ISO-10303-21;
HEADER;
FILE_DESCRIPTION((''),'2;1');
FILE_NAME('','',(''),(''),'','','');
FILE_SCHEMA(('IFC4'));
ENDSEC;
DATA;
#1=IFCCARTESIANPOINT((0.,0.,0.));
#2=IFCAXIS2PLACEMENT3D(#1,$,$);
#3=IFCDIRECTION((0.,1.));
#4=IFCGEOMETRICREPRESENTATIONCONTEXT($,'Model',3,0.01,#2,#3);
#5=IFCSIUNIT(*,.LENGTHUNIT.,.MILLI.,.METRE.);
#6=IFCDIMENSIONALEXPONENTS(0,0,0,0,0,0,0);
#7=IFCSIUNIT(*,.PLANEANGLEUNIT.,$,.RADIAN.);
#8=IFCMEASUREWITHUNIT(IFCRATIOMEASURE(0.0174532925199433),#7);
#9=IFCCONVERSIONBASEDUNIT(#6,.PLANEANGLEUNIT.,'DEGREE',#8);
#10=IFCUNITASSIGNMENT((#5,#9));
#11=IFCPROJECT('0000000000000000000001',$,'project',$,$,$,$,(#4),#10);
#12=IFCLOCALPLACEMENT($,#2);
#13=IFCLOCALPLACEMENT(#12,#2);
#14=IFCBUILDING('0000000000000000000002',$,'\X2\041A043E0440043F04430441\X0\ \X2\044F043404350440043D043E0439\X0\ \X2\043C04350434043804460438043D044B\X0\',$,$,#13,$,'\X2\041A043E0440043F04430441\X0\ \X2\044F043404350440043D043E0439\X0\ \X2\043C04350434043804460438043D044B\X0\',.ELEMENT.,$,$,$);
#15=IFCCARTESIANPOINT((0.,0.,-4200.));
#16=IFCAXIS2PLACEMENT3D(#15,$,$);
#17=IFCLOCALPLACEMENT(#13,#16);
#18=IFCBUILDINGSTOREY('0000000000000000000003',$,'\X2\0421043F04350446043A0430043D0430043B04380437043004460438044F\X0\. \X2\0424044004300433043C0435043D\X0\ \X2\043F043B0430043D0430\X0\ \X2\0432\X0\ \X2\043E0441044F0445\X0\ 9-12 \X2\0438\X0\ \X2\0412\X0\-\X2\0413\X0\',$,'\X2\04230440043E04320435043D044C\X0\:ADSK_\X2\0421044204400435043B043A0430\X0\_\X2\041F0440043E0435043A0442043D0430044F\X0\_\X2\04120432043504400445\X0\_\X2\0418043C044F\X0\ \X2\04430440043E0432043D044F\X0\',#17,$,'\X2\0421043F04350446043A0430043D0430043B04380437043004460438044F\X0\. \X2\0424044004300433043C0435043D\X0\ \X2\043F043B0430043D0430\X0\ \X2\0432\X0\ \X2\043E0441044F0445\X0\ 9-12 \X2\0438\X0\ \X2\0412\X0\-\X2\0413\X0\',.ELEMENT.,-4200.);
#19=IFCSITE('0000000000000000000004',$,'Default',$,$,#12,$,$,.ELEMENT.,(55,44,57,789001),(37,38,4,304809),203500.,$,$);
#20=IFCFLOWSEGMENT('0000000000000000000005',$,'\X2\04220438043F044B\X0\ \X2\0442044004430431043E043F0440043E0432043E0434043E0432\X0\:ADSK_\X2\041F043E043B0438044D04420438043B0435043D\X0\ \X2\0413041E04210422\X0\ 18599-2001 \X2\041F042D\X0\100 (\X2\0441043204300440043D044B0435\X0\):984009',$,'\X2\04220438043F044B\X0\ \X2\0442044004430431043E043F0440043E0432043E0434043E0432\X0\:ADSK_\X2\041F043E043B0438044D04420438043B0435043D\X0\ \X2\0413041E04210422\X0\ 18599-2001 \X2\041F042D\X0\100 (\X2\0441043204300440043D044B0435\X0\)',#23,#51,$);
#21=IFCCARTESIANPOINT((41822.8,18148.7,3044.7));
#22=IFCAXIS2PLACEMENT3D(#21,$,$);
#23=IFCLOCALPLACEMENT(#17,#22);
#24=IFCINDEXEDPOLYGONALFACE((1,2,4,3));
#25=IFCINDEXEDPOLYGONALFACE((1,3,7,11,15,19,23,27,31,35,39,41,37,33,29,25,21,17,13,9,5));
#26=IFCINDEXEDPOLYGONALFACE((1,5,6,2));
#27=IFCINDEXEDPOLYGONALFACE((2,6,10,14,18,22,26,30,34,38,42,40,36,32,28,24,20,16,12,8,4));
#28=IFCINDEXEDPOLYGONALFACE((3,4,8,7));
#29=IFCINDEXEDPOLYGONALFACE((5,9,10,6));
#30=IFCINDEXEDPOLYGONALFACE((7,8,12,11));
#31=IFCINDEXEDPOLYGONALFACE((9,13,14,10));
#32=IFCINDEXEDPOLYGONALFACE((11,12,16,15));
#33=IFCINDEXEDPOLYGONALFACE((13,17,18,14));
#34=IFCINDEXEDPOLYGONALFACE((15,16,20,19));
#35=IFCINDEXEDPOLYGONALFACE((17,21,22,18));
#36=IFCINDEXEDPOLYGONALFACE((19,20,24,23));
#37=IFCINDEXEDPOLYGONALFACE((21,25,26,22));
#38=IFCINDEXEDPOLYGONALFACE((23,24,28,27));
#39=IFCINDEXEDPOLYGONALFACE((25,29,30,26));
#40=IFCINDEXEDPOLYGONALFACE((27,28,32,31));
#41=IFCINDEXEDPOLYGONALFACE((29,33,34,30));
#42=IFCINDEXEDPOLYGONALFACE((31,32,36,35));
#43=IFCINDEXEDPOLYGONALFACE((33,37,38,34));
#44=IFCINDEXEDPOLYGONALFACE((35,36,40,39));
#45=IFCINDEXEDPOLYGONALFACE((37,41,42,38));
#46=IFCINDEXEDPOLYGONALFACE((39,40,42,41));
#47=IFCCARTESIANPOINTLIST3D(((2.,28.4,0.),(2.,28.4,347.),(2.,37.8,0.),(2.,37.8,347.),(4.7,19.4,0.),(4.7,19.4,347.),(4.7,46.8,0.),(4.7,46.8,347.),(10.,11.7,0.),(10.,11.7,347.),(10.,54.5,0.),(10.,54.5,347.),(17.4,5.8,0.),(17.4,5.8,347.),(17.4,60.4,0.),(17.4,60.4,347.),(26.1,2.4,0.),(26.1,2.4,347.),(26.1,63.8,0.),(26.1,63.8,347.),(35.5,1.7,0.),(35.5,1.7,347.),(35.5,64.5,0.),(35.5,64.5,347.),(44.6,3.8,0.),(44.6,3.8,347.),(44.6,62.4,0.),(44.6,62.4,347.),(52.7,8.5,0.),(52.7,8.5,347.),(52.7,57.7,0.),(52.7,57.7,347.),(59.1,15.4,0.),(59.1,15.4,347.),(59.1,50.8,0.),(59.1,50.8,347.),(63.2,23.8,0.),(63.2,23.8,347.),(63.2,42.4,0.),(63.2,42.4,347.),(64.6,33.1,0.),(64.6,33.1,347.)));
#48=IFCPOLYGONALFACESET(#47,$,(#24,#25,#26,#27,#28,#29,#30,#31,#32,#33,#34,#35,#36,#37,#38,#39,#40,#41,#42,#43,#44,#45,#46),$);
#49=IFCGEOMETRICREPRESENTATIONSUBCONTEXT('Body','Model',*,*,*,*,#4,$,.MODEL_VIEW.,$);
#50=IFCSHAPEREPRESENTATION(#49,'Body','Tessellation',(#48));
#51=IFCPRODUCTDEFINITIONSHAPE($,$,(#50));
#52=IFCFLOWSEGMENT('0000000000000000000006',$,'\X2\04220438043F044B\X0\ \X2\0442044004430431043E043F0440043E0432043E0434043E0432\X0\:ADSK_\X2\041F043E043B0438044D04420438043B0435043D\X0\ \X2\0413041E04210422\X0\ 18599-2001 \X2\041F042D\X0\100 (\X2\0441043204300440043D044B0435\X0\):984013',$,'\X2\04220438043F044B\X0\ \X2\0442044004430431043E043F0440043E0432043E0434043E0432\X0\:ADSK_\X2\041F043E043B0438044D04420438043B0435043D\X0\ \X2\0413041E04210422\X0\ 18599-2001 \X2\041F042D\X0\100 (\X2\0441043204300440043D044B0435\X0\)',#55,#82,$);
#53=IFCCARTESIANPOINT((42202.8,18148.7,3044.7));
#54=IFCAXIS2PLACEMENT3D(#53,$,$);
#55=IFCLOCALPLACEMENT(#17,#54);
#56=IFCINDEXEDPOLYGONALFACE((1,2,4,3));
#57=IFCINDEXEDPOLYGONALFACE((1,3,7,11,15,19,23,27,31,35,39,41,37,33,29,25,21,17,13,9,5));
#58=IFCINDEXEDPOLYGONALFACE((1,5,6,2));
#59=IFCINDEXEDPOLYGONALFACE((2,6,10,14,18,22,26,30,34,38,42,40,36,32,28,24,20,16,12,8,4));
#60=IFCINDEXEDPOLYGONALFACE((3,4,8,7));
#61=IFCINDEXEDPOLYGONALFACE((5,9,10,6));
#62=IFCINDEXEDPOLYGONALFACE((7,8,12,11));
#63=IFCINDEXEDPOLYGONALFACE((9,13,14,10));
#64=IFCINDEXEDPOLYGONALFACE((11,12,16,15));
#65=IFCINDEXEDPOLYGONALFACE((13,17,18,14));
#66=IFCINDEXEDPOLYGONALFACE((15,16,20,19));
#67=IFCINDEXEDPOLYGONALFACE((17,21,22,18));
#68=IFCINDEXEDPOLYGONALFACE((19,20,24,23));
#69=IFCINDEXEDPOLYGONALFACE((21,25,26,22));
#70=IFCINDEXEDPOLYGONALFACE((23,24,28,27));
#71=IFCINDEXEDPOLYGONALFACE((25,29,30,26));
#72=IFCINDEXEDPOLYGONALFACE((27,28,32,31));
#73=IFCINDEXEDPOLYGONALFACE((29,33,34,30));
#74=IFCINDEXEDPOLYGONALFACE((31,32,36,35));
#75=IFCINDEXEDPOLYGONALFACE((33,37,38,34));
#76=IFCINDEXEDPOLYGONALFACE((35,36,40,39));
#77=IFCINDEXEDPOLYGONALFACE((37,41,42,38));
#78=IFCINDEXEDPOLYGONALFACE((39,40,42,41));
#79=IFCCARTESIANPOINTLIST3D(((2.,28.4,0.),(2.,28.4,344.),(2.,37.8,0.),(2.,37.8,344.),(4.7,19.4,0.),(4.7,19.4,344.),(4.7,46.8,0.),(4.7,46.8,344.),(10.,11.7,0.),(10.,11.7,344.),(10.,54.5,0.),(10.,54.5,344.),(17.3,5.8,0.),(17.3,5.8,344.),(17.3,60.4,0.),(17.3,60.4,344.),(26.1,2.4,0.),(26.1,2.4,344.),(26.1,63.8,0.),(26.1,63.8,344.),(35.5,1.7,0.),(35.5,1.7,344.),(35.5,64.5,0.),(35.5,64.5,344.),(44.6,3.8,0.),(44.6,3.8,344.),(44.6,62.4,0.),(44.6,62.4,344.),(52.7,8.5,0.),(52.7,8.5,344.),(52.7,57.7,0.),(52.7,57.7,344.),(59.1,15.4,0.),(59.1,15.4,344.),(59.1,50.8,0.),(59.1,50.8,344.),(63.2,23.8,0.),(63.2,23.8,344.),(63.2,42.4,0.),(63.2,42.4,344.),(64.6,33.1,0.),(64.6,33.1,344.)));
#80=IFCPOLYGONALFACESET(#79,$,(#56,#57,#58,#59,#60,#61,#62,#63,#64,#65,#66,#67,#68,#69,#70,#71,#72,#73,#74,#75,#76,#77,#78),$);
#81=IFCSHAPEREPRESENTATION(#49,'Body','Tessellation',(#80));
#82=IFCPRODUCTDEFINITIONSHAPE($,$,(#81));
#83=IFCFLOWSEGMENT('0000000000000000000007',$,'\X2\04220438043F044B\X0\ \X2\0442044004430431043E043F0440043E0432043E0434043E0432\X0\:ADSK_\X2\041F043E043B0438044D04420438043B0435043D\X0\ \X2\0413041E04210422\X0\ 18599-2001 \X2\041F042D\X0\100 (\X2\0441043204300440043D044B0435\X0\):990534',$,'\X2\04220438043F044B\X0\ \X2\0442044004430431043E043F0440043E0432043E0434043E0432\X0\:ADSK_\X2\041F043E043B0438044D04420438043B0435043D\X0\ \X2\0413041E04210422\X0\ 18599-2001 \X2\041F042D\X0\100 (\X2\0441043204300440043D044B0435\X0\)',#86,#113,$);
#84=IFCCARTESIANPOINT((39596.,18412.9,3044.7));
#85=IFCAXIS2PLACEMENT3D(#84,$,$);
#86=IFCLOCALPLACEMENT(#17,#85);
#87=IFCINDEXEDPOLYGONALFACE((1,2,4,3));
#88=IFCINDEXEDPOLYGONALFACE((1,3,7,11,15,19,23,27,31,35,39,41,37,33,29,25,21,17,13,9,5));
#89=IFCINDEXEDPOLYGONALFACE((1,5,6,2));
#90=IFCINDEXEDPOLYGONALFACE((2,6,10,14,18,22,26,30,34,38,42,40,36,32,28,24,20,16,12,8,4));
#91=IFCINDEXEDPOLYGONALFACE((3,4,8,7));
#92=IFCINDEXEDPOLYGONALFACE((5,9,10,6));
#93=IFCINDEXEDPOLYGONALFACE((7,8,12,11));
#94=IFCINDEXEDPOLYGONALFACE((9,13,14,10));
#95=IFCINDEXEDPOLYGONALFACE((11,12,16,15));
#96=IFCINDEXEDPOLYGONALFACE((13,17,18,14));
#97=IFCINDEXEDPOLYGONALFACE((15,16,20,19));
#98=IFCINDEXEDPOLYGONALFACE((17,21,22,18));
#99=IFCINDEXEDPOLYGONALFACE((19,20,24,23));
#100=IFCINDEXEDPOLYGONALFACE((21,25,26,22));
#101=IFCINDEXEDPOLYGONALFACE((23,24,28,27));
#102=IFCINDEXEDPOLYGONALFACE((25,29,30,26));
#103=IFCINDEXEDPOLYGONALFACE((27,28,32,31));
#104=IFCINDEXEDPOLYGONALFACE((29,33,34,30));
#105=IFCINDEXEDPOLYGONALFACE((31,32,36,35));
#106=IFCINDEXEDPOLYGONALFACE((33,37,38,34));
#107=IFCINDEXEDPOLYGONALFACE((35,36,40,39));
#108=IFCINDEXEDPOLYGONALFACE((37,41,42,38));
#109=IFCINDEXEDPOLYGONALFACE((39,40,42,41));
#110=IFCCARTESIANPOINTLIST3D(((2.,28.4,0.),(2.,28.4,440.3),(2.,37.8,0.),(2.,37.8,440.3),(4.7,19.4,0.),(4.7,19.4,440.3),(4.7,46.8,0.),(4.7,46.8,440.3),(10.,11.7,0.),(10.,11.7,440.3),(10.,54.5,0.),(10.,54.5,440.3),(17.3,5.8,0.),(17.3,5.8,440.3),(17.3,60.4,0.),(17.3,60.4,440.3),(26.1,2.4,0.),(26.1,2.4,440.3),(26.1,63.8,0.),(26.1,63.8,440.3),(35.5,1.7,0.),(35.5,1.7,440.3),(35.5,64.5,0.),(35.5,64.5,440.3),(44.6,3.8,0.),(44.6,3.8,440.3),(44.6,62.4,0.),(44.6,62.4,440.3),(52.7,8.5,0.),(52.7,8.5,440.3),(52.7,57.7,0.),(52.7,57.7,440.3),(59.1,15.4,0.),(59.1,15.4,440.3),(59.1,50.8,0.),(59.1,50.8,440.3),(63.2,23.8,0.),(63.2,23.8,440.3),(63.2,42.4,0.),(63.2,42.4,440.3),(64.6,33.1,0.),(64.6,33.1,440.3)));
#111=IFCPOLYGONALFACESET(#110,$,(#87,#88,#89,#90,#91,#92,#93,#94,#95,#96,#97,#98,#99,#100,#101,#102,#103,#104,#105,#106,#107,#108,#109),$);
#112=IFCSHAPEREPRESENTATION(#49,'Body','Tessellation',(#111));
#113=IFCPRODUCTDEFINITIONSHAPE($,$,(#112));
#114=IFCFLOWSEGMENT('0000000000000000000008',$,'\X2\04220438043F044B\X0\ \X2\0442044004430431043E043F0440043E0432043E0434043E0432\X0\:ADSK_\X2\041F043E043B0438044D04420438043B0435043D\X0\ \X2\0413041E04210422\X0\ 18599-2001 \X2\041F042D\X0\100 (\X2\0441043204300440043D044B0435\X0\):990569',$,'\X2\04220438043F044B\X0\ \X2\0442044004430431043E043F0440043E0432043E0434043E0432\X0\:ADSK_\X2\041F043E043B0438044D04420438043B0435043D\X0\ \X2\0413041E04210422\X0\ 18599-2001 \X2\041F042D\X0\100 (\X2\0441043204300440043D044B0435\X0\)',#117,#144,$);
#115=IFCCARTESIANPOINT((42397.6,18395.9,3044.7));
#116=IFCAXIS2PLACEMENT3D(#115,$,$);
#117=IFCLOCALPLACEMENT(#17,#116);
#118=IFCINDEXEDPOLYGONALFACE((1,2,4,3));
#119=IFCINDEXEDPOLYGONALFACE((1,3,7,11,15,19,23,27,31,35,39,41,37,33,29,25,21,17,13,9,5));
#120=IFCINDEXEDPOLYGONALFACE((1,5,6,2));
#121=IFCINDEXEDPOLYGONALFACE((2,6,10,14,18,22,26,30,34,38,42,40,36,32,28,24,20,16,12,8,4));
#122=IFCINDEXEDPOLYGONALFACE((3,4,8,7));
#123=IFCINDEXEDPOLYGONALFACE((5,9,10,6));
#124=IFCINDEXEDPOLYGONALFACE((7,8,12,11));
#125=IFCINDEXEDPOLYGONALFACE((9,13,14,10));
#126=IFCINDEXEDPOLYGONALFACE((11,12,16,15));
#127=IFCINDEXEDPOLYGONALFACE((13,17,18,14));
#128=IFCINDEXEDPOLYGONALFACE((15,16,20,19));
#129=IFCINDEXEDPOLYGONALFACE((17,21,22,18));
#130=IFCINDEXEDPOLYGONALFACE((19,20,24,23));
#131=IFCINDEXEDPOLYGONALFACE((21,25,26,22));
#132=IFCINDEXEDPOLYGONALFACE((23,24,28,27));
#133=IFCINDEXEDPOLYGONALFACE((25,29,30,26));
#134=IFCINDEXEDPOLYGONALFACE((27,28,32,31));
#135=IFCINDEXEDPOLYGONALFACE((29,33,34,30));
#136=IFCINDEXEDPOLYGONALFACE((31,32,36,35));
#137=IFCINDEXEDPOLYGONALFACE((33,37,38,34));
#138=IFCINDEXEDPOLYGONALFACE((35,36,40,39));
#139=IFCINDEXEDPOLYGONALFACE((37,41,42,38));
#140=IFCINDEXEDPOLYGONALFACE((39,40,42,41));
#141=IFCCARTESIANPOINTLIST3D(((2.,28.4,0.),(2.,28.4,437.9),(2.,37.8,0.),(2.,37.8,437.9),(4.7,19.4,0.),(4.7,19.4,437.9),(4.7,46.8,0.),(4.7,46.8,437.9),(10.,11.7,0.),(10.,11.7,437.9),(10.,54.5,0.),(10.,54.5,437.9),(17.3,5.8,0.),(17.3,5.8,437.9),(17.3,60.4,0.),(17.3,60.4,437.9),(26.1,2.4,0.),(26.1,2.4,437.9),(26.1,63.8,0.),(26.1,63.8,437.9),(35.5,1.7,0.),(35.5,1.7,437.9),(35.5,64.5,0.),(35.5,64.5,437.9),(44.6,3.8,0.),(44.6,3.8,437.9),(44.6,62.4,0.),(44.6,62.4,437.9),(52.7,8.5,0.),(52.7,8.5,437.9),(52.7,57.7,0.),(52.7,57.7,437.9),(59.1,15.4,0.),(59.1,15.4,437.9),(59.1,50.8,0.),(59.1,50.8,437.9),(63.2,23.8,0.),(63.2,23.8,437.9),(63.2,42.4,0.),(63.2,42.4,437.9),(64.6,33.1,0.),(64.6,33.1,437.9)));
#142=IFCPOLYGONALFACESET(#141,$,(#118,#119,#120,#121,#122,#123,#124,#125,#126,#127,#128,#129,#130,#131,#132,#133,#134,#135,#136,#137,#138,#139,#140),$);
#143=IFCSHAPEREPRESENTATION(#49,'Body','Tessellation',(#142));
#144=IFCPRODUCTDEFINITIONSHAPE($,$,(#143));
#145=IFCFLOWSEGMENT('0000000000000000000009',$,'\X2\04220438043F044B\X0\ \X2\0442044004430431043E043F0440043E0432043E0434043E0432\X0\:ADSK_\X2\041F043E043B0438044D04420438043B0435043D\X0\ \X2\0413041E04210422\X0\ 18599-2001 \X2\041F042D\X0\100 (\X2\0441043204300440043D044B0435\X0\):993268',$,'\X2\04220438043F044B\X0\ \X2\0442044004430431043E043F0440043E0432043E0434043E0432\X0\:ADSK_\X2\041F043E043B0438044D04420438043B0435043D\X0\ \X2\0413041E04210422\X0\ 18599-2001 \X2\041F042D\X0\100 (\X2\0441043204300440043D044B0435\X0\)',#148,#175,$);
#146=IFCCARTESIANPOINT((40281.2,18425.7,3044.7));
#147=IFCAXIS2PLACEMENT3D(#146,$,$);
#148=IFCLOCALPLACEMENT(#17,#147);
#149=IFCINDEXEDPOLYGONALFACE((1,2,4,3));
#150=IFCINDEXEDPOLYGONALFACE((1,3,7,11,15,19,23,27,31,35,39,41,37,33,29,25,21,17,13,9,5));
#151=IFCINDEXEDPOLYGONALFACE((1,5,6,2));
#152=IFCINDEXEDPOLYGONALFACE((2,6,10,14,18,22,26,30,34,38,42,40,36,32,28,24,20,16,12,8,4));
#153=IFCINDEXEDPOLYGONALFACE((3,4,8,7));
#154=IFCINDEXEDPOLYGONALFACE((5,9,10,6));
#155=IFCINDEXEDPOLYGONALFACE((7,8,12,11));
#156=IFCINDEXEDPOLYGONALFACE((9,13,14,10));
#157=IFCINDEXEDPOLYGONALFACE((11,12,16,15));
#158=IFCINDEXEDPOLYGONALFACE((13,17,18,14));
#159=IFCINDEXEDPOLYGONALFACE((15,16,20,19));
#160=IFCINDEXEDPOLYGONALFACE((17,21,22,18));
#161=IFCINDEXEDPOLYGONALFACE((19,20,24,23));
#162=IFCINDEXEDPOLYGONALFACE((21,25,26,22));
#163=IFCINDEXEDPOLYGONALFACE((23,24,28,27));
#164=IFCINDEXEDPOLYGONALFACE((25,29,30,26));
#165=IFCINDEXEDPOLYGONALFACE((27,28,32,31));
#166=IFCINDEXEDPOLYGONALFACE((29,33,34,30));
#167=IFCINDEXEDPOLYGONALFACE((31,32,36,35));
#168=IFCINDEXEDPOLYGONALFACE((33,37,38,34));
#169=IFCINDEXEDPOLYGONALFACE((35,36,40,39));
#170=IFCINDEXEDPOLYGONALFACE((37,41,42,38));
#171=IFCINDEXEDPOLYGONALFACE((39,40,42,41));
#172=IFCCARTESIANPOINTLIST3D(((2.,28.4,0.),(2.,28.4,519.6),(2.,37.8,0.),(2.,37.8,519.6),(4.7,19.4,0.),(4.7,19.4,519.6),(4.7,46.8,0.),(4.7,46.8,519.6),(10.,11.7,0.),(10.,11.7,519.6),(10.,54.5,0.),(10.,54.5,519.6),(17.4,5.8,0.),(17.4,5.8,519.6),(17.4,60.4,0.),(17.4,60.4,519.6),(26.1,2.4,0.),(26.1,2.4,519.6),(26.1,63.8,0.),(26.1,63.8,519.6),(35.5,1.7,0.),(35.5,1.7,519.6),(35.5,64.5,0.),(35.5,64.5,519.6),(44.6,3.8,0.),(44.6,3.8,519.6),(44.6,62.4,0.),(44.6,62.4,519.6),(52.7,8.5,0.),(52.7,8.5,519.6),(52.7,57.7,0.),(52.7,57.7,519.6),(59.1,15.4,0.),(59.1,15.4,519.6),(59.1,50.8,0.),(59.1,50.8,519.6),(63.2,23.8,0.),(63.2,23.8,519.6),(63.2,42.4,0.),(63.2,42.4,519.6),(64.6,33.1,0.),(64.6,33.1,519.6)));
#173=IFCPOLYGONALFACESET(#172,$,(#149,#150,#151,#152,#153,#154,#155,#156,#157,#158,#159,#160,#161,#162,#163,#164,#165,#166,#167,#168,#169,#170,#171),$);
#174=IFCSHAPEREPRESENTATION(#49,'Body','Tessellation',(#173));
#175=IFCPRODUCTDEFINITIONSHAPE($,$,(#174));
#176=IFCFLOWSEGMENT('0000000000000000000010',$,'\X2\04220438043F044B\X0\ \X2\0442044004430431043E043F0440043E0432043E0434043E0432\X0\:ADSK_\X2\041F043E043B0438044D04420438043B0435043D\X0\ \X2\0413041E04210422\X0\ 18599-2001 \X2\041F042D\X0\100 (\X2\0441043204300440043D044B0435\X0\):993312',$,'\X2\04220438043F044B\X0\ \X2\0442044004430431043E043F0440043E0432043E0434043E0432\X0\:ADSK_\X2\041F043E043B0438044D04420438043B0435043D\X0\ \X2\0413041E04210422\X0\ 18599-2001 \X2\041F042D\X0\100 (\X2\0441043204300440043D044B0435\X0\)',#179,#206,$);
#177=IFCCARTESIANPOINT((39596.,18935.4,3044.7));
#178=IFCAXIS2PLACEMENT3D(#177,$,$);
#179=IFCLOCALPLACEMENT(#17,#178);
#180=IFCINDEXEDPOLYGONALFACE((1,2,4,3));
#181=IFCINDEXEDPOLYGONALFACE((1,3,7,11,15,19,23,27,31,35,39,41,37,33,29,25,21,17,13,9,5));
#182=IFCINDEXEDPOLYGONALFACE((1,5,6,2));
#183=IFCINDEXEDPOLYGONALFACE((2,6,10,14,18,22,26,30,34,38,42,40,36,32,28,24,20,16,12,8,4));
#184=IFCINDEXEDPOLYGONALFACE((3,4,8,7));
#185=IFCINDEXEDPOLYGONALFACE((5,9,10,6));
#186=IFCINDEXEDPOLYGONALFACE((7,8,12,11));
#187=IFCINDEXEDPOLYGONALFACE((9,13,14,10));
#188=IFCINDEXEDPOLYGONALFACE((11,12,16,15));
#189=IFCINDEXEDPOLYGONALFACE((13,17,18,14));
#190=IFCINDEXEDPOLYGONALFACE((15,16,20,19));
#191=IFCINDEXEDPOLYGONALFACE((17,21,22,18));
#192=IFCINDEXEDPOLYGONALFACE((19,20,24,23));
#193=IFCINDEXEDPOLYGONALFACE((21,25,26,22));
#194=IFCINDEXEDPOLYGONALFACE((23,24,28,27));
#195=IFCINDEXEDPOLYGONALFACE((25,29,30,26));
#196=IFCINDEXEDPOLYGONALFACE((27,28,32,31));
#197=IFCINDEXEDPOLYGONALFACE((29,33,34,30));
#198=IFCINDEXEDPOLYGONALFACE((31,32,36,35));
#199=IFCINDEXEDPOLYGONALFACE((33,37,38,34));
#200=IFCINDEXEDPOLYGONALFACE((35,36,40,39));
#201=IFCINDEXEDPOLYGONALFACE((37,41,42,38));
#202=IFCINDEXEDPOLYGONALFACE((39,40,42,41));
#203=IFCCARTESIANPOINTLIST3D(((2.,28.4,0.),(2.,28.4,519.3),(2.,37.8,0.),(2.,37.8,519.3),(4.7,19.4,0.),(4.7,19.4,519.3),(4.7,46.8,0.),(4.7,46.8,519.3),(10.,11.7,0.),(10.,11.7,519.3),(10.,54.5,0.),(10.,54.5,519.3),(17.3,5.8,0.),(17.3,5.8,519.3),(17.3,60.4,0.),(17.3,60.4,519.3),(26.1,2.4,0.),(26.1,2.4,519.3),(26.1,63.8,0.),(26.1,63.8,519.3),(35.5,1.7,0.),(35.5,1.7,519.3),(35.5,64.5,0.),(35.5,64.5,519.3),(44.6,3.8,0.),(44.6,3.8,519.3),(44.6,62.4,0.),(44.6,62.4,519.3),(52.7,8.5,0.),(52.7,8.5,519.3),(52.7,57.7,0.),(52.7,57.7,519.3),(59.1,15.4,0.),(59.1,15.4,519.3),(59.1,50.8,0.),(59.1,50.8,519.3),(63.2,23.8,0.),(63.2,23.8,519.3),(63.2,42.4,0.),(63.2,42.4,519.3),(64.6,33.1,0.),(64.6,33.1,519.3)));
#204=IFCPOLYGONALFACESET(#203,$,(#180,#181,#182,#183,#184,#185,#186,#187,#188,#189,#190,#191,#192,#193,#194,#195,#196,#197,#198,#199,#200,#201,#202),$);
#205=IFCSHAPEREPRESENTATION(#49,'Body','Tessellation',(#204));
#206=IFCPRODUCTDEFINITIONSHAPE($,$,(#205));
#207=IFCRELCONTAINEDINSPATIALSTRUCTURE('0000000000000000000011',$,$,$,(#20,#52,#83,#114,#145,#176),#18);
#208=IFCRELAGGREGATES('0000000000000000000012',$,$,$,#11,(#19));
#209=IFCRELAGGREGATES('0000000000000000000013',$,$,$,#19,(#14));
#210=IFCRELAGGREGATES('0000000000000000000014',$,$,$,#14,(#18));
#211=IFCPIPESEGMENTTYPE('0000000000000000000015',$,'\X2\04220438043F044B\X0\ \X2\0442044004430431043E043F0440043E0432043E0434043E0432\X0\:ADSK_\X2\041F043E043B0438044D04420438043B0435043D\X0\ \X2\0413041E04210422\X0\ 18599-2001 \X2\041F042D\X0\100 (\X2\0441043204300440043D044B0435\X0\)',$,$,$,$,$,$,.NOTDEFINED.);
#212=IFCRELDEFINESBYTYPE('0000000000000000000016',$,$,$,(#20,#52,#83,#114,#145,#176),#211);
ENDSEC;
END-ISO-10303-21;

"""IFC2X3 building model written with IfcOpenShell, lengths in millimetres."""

from ifc_helpers import new_model, entity, si_unit, converted_unit, direction, frame, origin, origin_2d_with_axis, place, context, subcontext, project, spatial, circle, extrude, type_object, element, save


model = new_model("IFC2X3")

# Units and contexts
model_context = context("Model", 3, precision=0.01, world=origin(), true_north=direction((0.0, 1.0)))
body_context = subcontext(model_context, "Body", "Model", "MODEL_VIEW")
ifc_project = project(units=[si_unit("LENGTHUNIT", "METRE", prefix="MILLI"), converted_unit("PLANEANGLEUNIT", "DEGREE", entity("IfcRatioMeasure", 0.0174532925199433), si_unit("PLANEANGLEUNIT", "RADIAN"), dimensions=[0, 0, 0, 0, 0, 0, 0])], contexts=[model_context])

# Site, building, storey
site_placement = place(None, origin())
site = spatial("IfcSite", under=ifc_project, at=site_placement, Name="Default", CompositionType="ELEMENT", RefLatitude=(55, 44, 57, 789001), RefLongitude=(37, 38, 4, 304809), RefElevation=203500.0)
building_placement = place(site_placement, origin())
building = spatial("IfcBuilding", under=site, at=building_placement, Name="Корпус ядерной медицины", LongName="Корпус ядерной медицины", CompositionType="ELEMENT")
storey_placement = place(building_placement, frame((0.0, 0.0, -4200.0)))
storey = spatial("IfcBuildingStorey", under=building, at=storey_placement, Name="Спецканализация. Фрагмен плана в осях 9-12 и В-Г", ObjectType="Уровень:ADSK_Стрелка_Проектная_Вверх_Имя уровня", LongName="Спецканализация. Фрагмен плана в осях 9-12 и В-Г", CompositionType="ELEMENT", Elevation=-4200.0)

# Flow segments
pipe_segment_type = type_object("IfcPipeSegmentType", Name="Типы трубопроводов:ADSK_Полиэтилен ГОСТ 18599-2001 ПЭ100 (сварные)", PredefinedType="NOTDEFINED")
flow_segment_1_placement = place(storey_placement, frame((41822.8, 18148.7, 3044.7)))
element("IfcFlowSegment", 1, at=flow_segment_1_placement, inside=storey, type_object=pipe_segment_type, Name="Типы трубопроводов:ADSK_Полиэтилен ГОСТ 18599-2001 ПЭ100 (сварные):984009", ObjectType="Типы трубопроводов:ADSK_Полиэтилен ГОСТ 18599-2001 ПЭ100 (сварные)", context=body_context, shape_type="SweptSolid", body=[
    extrude(circle(Radius=31.5, at=origin_2d_with_axis()), frame((33.1, 33.1, 0.0)), (0.0, 0.0, 1.0), 347.0),
])
flow_segment_2_placement = place(storey_placement, frame((42202.8, 18148.7, 3044.7)))
element("IfcFlowSegment", 2, at=flow_segment_2_placement, inside=storey, type_object=pipe_segment_type, Name="Типы трубопроводов:ADSK_Полиэтилен ГОСТ 18599-2001 ПЭ100 (сварные):984013", ObjectType="Типы трубопроводов:ADSK_Полиэтилен ГОСТ 18599-2001 ПЭ100 (сварные)", context=body_context, shape_type="SweptSolid", body=[
    extrude(circle(Radius=31.5, at=origin_2d_with_axis()), frame((33.1, 33.1, 0.0)), (0.0, 0.0, 1.0), 344.0),
])
flow_segment_3_placement = place(storey_placement, frame((39596.0, 18412.9, 3044.7)))
element("IfcFlowSegment", 3, at=flow_segment_3_placement, inside=storey, type_object=pipe_segment_type, Name="Типы трубопроводов:ADSK_Полиэтилен ГОСТ 18599-2001 ПЭ100 (сварные):990534", ObjectType="Типы трубопроводов:ADSK_Полиэтилен ГОСТ 18599-2001 ПЭ100 (сварные)", context=body_context, shape_type="SweptSolid", body=[
    extrude(circle(Radius=31.5, at=origin_2d_with_axis()), frame((33.1, 33.1, 0.0)), (0.0, 0.0, 1.0), 440.3),
])
flow_segment_4_placement = place(storey_placement, frame((42397.6, 18395.9, 3044.7)))
element("IfcFlowSegment", 4, at=flow_segment_4_placement, inside=storey, type_object=pipe_segment_type, Name="Типы трубопроводов:ADSK_Полиэтилен ГОСТ 18599-2001 ПЭ100 (сварные):990569", ObjectType="Типы трубопроводов:ADSK_Полиэтилен ГОСТ 18599-2001 ПЭ100 (сварные)", context=body_context, shape_type="SweptSolid", body=[
    extrude(circle(Radius=31.5, at=origin_2d_with_axis()), frame((33.1, 33.1, 0.0)), (0.0, 0.0, 1.0), 437.9),
])
flow_segment_5_placement = place(storey_placement, frame((40281.2, 18425.7, 3044.7)))
element("IfcFlowSegment", 5, at=flow_segment_5_placement, inside=storey, type_object=pipe_segment_type, Name="Типы трубопроводов:ADSK_Полиэтилен ГОСТ 18599-2001 ПЭ100 (сварные):993268", ObjectType="Типы трубопроводов:ADSK_Полиэтилен ГОСТ 18599-2001 ПЭ100 (сварные)", context=body_context, shape_type="SweptSolid", body=[
    extrude(circle(Radius=31.5, at=origin_2d_with_axis()), frame((33.1, 33.1, 0.0)), (0.0, 0.0, 1.0), 519.6),
])
flow_segment_6_placement = place(storey_placement, frame((39596.0, 18935.4, 3044.7)))
element("IfcFlowSegment", 6, at=flow_segment_6_placement, inside=storey, type_object=pipe_segment_type, Name="Типы трубопроводов:ADSK_Полиэтилен ГОСТ 18599-2001 ПЭ100 (сварные):993312", ObjectType="Типы трубопроводов:ADSK_Полиэтилен ГОСТ 18599-2001 ПЭ100 (сварные)", context=body_context, shape_type="SweptSolid", body=[
    extrude(circle(Radius=31.5, at=origin_2d_with_axis()), frame((33.1, 33.1, 0.0)), (0.0, 0.0, 1.0), 519.3),
])

save(model, "model.ifc")
